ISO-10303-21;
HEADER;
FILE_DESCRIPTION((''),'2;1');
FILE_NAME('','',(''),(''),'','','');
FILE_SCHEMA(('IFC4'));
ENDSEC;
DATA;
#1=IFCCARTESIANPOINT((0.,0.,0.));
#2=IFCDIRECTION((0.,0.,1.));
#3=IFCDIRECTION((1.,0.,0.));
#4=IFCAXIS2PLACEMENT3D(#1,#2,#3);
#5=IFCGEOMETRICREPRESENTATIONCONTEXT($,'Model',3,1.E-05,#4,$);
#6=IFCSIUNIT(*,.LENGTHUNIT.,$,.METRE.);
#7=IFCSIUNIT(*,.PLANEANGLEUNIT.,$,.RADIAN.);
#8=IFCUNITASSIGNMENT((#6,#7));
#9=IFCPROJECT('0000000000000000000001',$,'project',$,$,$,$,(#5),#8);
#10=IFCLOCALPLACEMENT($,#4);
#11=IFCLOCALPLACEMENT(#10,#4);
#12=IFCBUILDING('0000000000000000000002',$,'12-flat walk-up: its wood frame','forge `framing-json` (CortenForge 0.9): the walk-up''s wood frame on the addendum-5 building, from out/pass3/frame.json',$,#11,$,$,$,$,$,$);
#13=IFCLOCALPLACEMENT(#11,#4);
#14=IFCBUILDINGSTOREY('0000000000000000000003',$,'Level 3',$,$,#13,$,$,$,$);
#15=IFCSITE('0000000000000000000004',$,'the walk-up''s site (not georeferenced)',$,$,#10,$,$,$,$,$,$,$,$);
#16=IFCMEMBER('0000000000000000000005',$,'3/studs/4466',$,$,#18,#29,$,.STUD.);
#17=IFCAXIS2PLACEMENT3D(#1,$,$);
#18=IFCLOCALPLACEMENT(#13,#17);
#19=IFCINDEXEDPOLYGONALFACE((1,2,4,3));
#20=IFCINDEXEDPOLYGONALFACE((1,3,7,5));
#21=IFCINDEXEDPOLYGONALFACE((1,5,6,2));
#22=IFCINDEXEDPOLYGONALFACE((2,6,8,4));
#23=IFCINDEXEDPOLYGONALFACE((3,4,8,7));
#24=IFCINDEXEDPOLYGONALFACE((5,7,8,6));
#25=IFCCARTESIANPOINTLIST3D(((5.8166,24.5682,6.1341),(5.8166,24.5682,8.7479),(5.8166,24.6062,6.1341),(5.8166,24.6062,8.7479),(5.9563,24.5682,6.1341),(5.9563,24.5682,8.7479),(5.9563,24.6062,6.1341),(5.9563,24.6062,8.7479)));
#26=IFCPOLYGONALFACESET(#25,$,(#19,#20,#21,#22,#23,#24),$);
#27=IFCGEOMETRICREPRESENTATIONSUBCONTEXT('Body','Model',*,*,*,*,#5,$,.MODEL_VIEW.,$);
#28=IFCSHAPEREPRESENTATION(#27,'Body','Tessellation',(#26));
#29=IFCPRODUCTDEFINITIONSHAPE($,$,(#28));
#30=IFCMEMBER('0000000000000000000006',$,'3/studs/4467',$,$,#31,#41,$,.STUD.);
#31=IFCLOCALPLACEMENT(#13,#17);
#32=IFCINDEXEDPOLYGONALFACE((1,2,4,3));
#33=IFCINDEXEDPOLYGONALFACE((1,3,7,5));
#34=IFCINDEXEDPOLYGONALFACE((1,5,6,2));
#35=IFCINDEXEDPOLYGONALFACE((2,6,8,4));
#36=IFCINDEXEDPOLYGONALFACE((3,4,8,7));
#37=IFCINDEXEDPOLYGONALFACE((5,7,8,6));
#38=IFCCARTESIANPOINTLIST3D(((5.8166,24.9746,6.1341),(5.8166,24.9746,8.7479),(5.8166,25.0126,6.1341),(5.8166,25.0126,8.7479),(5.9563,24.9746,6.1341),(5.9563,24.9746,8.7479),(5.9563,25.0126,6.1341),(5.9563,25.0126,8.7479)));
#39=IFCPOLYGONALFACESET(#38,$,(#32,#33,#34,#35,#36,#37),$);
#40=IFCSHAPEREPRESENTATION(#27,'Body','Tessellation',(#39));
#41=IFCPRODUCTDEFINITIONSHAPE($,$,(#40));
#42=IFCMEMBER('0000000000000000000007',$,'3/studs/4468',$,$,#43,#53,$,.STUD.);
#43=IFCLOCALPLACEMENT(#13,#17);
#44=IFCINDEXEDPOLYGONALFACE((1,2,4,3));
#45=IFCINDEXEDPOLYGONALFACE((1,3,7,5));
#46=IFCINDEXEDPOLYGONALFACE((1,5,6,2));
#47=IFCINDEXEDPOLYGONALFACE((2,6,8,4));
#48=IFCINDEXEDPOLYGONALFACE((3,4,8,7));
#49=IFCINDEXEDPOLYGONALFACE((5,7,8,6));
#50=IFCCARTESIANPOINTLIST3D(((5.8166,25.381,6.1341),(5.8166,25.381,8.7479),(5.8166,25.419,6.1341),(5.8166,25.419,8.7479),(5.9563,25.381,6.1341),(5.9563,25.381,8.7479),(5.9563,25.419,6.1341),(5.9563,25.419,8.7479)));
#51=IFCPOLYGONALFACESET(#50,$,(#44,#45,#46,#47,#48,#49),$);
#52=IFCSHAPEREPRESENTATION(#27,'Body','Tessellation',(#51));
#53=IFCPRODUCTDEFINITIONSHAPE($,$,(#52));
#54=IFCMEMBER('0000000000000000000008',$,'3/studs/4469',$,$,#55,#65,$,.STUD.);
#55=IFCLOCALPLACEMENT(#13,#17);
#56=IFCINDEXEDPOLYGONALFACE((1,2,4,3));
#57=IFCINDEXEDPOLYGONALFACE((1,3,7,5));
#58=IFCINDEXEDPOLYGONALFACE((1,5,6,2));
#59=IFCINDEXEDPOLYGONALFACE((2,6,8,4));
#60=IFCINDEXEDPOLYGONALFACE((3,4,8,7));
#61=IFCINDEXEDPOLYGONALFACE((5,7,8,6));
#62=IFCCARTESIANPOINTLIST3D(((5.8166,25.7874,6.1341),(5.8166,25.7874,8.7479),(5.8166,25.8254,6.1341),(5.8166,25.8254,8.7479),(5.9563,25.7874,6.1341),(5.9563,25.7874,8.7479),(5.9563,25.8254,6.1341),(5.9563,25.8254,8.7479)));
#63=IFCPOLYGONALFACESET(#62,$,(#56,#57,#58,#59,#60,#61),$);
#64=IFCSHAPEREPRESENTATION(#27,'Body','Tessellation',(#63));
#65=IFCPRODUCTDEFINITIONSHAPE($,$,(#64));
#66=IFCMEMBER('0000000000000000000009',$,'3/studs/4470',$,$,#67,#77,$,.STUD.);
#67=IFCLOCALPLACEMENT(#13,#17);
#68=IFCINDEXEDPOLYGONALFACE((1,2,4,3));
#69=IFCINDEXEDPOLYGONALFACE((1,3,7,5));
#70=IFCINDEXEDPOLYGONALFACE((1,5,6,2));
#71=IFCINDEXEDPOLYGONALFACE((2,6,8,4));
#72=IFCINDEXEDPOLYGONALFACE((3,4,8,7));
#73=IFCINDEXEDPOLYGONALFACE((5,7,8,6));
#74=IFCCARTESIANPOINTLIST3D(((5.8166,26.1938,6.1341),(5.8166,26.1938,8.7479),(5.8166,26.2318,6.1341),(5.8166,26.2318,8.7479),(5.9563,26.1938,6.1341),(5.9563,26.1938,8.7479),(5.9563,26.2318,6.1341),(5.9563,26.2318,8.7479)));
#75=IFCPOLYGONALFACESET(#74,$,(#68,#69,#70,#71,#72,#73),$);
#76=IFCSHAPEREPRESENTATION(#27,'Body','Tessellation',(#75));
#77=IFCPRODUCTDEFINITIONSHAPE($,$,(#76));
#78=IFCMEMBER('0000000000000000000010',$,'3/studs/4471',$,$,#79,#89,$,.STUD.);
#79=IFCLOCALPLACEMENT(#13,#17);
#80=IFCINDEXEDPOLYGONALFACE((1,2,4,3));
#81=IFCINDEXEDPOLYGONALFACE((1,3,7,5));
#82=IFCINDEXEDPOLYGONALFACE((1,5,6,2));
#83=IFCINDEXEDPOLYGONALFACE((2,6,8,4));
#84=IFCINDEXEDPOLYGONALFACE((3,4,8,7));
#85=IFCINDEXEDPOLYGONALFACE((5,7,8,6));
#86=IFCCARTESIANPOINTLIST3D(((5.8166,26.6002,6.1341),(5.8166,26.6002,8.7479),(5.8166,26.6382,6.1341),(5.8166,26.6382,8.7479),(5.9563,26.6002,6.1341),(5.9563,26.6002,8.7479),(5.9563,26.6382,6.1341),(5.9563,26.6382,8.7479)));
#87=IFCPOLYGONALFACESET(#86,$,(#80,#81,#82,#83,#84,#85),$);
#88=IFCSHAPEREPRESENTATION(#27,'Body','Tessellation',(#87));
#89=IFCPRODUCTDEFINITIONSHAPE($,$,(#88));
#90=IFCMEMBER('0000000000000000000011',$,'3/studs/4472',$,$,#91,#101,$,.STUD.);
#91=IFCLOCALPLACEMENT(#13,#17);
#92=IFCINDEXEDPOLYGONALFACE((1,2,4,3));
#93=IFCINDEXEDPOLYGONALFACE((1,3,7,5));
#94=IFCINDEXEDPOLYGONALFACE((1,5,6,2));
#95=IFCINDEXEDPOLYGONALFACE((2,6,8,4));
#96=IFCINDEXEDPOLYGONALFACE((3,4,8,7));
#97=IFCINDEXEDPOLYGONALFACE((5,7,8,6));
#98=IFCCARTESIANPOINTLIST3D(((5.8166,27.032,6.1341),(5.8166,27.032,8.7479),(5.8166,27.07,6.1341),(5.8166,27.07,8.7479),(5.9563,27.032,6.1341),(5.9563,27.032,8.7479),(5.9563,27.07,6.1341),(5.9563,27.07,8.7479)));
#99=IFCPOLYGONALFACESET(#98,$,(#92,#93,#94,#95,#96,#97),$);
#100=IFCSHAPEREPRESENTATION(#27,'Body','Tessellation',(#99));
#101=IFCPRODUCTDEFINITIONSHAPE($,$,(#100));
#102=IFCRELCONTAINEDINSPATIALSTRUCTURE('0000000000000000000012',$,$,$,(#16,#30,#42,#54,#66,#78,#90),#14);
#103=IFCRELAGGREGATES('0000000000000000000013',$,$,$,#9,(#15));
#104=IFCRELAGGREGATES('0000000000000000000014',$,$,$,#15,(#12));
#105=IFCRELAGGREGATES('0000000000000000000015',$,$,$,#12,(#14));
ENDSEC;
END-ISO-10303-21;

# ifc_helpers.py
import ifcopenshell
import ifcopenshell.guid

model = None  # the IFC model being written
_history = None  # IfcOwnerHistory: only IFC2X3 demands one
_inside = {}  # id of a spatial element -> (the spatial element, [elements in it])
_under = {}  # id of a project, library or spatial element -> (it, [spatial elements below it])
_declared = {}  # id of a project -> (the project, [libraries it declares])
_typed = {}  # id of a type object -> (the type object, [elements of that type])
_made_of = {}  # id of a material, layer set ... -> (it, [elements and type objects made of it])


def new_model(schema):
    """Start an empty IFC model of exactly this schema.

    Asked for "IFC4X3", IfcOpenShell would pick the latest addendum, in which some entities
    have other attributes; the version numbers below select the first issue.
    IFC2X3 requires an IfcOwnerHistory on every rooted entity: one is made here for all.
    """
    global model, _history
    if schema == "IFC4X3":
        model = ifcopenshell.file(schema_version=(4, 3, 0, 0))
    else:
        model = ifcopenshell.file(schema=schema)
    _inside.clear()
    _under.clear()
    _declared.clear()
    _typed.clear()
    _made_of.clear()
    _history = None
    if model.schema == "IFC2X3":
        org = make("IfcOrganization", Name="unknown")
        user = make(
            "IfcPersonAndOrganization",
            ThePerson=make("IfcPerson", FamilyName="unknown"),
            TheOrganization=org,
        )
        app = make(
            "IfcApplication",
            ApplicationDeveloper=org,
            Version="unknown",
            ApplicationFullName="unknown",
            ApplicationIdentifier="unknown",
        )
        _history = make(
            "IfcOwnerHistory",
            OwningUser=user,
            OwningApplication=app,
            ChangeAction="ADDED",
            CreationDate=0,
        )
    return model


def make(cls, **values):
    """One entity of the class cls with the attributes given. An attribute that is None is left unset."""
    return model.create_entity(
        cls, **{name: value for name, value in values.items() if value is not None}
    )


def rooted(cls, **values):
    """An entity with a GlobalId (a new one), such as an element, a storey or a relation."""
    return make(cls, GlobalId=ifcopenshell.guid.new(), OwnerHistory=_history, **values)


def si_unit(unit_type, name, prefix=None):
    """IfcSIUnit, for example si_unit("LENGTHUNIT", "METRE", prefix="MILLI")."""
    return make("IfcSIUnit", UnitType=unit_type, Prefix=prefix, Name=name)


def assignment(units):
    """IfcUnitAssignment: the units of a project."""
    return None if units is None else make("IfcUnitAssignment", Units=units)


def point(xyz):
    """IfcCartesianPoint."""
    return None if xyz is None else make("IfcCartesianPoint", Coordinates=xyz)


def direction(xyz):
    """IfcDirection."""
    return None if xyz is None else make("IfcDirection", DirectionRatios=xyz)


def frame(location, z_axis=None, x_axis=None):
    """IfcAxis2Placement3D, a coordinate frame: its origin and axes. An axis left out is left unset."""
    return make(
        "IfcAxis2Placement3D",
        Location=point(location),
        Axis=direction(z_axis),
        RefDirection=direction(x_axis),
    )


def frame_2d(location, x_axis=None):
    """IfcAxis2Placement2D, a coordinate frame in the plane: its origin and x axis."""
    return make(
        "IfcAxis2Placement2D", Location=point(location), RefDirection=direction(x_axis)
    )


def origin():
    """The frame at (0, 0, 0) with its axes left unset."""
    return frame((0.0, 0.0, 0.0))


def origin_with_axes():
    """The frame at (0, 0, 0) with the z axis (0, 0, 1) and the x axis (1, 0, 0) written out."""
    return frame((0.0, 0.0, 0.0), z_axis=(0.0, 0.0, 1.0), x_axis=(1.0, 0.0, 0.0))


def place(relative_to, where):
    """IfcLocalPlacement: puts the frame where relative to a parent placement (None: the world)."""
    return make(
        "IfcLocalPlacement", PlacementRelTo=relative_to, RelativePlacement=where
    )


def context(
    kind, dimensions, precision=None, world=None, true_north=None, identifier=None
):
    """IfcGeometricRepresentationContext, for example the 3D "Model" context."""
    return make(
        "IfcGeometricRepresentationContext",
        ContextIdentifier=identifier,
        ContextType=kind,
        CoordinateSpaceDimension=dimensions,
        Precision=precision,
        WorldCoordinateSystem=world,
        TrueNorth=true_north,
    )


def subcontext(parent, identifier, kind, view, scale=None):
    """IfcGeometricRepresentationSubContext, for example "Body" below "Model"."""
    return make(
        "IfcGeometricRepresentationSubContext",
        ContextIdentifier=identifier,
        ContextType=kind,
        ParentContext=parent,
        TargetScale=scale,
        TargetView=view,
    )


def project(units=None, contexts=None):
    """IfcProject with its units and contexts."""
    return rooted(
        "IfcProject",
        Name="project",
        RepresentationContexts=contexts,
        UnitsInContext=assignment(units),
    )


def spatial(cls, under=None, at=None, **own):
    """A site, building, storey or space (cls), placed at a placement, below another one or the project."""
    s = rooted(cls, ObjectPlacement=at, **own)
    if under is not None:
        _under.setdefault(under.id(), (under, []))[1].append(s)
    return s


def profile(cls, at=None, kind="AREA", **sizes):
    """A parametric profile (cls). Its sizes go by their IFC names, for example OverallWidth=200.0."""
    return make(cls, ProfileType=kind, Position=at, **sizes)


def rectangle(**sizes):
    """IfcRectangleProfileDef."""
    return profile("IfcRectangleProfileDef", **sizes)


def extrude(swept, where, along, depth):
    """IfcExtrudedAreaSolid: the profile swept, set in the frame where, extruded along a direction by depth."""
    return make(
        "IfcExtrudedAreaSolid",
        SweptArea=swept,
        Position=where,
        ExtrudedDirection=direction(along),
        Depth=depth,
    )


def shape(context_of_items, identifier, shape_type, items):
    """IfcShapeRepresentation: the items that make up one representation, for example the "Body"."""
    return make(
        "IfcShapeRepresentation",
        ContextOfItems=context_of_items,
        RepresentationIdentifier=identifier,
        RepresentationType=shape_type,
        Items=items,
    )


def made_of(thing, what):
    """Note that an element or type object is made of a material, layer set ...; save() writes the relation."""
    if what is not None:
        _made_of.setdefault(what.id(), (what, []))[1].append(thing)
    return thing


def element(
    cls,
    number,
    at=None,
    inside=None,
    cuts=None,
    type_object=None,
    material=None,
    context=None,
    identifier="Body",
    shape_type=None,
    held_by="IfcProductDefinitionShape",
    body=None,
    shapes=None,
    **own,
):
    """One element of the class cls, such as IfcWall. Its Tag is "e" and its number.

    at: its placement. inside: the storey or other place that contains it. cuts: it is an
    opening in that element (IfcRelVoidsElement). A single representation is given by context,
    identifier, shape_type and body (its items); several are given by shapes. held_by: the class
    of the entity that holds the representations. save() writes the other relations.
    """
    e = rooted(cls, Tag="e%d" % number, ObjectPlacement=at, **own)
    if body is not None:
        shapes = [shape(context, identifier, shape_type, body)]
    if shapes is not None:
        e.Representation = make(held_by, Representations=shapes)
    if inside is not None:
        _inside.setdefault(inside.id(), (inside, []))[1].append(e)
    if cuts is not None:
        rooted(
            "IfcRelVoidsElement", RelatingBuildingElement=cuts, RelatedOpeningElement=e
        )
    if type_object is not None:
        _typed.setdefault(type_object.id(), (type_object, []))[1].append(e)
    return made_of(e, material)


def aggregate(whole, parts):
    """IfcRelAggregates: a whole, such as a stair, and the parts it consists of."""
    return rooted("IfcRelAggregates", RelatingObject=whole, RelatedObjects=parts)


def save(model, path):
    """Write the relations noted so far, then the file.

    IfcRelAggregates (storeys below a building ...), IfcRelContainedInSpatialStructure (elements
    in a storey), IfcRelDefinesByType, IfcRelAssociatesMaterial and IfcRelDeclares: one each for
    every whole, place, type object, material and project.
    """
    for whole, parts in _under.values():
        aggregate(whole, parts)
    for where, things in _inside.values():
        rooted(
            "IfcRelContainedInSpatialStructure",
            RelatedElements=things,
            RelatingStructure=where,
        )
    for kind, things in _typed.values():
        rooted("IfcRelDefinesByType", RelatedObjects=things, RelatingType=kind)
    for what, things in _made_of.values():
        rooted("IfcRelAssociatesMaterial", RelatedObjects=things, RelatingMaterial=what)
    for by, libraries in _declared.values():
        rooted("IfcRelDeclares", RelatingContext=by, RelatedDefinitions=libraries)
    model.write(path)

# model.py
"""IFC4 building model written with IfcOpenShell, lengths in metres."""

from ifc_helpers import new_model, si_unit, frame, frame_2d, origin, origin_with_axes, place, context, subcontext, project, spatial, rectangle, extrude, element, save


model = new_model("IFC4")

# Units and contexts
model_context = context("Model", 3, precision=1e-05, world=origin_with_axes())
body_context = subcontext(model_context, "Body", "Model", "MODEL_VIEW")
ifc_project = project(units=[si_unit("LENGTHUNIT", "METRE"), si_unit("PLANEANGLEUNIT", "RADIAN")], contexts=[model_context])

# Site, building, storey
site_placement = place(None, origin_with_axes())
site = spatial("IfcSite", under=ifc_project, at=site_placement, Name="the walk-up's site (not georeferenced)")
building_placement = place(site_placement, origin_with_axes())
building = spatial("IfcBuilding", under=site, at=building_placement, Name="12-flat walk-up: its wood frame", Description="forge `framing-json` (CortenForge 0.9): the walk-up's wood frame on the addendum-5 building, from out/pass3/frame.json")
storey_placement = place(building_placement, origin_with_axes())
storey = spatial("IfcBuildingStorey", under=building, at=storey_placement, Name="Level 3")

# Members
for number, where, z_axis, x_axis, name in (
    (1, (5.8166, 24.5681, 6.1341), (0.0, 0.0, 1.0), (1.0, 0.0, 0.0), "3/studs/4466"),
    (2, (5.8166, 24.9746, 6.1341), (0.0, 0.0, 1.0), (1.0, 0.0, 0.0), "3/studs/4467"),
    (3, (5.8166, 25.3809, 6.1341), (0.0, 0.0, 1.0), (1.0, 0.0, 0.0), "3/studs/4468"),
    (4, (5.8166, 25.7873, 6.1341), (0.0, 0.0, 1.0), (1.0, 0.0, 0.0), "3/studs/4469"),
    (5, (5.8166, 26.1938, 6.1341), (0.0, 0.0, 1.0), (1.0, 0.0, 0.0), "3/studs/4470"),
    (6, (5.8166, 26.6001, 6.1341), (0.0, 0.0, 1.0), (1.0, 0.0, 0.0), "3/studs/4471"),
    (7, (5.8166, 27.0319, 6.1341), (0.0, 0.0, 1.0), (1.0, 0.0, 0.0), "3/studs/4472"),
):
    element("IfcMember", number, at=place(storey_placement, frame(where, z_axis=z_axis, x_axis=x_axis)), inside=storey, Name=name, PredefinedType="STUD", context=body_context, shape_type="SweptSolid", body=[
        extrude(rectangle(XDim=0.1397, YDim=0.0381, at=frame_2d((0.0698, 0.0191))), origin(), (0.0, 0.0, 1.0), 2.6138),
    ])

save(model, "model.ifc")
